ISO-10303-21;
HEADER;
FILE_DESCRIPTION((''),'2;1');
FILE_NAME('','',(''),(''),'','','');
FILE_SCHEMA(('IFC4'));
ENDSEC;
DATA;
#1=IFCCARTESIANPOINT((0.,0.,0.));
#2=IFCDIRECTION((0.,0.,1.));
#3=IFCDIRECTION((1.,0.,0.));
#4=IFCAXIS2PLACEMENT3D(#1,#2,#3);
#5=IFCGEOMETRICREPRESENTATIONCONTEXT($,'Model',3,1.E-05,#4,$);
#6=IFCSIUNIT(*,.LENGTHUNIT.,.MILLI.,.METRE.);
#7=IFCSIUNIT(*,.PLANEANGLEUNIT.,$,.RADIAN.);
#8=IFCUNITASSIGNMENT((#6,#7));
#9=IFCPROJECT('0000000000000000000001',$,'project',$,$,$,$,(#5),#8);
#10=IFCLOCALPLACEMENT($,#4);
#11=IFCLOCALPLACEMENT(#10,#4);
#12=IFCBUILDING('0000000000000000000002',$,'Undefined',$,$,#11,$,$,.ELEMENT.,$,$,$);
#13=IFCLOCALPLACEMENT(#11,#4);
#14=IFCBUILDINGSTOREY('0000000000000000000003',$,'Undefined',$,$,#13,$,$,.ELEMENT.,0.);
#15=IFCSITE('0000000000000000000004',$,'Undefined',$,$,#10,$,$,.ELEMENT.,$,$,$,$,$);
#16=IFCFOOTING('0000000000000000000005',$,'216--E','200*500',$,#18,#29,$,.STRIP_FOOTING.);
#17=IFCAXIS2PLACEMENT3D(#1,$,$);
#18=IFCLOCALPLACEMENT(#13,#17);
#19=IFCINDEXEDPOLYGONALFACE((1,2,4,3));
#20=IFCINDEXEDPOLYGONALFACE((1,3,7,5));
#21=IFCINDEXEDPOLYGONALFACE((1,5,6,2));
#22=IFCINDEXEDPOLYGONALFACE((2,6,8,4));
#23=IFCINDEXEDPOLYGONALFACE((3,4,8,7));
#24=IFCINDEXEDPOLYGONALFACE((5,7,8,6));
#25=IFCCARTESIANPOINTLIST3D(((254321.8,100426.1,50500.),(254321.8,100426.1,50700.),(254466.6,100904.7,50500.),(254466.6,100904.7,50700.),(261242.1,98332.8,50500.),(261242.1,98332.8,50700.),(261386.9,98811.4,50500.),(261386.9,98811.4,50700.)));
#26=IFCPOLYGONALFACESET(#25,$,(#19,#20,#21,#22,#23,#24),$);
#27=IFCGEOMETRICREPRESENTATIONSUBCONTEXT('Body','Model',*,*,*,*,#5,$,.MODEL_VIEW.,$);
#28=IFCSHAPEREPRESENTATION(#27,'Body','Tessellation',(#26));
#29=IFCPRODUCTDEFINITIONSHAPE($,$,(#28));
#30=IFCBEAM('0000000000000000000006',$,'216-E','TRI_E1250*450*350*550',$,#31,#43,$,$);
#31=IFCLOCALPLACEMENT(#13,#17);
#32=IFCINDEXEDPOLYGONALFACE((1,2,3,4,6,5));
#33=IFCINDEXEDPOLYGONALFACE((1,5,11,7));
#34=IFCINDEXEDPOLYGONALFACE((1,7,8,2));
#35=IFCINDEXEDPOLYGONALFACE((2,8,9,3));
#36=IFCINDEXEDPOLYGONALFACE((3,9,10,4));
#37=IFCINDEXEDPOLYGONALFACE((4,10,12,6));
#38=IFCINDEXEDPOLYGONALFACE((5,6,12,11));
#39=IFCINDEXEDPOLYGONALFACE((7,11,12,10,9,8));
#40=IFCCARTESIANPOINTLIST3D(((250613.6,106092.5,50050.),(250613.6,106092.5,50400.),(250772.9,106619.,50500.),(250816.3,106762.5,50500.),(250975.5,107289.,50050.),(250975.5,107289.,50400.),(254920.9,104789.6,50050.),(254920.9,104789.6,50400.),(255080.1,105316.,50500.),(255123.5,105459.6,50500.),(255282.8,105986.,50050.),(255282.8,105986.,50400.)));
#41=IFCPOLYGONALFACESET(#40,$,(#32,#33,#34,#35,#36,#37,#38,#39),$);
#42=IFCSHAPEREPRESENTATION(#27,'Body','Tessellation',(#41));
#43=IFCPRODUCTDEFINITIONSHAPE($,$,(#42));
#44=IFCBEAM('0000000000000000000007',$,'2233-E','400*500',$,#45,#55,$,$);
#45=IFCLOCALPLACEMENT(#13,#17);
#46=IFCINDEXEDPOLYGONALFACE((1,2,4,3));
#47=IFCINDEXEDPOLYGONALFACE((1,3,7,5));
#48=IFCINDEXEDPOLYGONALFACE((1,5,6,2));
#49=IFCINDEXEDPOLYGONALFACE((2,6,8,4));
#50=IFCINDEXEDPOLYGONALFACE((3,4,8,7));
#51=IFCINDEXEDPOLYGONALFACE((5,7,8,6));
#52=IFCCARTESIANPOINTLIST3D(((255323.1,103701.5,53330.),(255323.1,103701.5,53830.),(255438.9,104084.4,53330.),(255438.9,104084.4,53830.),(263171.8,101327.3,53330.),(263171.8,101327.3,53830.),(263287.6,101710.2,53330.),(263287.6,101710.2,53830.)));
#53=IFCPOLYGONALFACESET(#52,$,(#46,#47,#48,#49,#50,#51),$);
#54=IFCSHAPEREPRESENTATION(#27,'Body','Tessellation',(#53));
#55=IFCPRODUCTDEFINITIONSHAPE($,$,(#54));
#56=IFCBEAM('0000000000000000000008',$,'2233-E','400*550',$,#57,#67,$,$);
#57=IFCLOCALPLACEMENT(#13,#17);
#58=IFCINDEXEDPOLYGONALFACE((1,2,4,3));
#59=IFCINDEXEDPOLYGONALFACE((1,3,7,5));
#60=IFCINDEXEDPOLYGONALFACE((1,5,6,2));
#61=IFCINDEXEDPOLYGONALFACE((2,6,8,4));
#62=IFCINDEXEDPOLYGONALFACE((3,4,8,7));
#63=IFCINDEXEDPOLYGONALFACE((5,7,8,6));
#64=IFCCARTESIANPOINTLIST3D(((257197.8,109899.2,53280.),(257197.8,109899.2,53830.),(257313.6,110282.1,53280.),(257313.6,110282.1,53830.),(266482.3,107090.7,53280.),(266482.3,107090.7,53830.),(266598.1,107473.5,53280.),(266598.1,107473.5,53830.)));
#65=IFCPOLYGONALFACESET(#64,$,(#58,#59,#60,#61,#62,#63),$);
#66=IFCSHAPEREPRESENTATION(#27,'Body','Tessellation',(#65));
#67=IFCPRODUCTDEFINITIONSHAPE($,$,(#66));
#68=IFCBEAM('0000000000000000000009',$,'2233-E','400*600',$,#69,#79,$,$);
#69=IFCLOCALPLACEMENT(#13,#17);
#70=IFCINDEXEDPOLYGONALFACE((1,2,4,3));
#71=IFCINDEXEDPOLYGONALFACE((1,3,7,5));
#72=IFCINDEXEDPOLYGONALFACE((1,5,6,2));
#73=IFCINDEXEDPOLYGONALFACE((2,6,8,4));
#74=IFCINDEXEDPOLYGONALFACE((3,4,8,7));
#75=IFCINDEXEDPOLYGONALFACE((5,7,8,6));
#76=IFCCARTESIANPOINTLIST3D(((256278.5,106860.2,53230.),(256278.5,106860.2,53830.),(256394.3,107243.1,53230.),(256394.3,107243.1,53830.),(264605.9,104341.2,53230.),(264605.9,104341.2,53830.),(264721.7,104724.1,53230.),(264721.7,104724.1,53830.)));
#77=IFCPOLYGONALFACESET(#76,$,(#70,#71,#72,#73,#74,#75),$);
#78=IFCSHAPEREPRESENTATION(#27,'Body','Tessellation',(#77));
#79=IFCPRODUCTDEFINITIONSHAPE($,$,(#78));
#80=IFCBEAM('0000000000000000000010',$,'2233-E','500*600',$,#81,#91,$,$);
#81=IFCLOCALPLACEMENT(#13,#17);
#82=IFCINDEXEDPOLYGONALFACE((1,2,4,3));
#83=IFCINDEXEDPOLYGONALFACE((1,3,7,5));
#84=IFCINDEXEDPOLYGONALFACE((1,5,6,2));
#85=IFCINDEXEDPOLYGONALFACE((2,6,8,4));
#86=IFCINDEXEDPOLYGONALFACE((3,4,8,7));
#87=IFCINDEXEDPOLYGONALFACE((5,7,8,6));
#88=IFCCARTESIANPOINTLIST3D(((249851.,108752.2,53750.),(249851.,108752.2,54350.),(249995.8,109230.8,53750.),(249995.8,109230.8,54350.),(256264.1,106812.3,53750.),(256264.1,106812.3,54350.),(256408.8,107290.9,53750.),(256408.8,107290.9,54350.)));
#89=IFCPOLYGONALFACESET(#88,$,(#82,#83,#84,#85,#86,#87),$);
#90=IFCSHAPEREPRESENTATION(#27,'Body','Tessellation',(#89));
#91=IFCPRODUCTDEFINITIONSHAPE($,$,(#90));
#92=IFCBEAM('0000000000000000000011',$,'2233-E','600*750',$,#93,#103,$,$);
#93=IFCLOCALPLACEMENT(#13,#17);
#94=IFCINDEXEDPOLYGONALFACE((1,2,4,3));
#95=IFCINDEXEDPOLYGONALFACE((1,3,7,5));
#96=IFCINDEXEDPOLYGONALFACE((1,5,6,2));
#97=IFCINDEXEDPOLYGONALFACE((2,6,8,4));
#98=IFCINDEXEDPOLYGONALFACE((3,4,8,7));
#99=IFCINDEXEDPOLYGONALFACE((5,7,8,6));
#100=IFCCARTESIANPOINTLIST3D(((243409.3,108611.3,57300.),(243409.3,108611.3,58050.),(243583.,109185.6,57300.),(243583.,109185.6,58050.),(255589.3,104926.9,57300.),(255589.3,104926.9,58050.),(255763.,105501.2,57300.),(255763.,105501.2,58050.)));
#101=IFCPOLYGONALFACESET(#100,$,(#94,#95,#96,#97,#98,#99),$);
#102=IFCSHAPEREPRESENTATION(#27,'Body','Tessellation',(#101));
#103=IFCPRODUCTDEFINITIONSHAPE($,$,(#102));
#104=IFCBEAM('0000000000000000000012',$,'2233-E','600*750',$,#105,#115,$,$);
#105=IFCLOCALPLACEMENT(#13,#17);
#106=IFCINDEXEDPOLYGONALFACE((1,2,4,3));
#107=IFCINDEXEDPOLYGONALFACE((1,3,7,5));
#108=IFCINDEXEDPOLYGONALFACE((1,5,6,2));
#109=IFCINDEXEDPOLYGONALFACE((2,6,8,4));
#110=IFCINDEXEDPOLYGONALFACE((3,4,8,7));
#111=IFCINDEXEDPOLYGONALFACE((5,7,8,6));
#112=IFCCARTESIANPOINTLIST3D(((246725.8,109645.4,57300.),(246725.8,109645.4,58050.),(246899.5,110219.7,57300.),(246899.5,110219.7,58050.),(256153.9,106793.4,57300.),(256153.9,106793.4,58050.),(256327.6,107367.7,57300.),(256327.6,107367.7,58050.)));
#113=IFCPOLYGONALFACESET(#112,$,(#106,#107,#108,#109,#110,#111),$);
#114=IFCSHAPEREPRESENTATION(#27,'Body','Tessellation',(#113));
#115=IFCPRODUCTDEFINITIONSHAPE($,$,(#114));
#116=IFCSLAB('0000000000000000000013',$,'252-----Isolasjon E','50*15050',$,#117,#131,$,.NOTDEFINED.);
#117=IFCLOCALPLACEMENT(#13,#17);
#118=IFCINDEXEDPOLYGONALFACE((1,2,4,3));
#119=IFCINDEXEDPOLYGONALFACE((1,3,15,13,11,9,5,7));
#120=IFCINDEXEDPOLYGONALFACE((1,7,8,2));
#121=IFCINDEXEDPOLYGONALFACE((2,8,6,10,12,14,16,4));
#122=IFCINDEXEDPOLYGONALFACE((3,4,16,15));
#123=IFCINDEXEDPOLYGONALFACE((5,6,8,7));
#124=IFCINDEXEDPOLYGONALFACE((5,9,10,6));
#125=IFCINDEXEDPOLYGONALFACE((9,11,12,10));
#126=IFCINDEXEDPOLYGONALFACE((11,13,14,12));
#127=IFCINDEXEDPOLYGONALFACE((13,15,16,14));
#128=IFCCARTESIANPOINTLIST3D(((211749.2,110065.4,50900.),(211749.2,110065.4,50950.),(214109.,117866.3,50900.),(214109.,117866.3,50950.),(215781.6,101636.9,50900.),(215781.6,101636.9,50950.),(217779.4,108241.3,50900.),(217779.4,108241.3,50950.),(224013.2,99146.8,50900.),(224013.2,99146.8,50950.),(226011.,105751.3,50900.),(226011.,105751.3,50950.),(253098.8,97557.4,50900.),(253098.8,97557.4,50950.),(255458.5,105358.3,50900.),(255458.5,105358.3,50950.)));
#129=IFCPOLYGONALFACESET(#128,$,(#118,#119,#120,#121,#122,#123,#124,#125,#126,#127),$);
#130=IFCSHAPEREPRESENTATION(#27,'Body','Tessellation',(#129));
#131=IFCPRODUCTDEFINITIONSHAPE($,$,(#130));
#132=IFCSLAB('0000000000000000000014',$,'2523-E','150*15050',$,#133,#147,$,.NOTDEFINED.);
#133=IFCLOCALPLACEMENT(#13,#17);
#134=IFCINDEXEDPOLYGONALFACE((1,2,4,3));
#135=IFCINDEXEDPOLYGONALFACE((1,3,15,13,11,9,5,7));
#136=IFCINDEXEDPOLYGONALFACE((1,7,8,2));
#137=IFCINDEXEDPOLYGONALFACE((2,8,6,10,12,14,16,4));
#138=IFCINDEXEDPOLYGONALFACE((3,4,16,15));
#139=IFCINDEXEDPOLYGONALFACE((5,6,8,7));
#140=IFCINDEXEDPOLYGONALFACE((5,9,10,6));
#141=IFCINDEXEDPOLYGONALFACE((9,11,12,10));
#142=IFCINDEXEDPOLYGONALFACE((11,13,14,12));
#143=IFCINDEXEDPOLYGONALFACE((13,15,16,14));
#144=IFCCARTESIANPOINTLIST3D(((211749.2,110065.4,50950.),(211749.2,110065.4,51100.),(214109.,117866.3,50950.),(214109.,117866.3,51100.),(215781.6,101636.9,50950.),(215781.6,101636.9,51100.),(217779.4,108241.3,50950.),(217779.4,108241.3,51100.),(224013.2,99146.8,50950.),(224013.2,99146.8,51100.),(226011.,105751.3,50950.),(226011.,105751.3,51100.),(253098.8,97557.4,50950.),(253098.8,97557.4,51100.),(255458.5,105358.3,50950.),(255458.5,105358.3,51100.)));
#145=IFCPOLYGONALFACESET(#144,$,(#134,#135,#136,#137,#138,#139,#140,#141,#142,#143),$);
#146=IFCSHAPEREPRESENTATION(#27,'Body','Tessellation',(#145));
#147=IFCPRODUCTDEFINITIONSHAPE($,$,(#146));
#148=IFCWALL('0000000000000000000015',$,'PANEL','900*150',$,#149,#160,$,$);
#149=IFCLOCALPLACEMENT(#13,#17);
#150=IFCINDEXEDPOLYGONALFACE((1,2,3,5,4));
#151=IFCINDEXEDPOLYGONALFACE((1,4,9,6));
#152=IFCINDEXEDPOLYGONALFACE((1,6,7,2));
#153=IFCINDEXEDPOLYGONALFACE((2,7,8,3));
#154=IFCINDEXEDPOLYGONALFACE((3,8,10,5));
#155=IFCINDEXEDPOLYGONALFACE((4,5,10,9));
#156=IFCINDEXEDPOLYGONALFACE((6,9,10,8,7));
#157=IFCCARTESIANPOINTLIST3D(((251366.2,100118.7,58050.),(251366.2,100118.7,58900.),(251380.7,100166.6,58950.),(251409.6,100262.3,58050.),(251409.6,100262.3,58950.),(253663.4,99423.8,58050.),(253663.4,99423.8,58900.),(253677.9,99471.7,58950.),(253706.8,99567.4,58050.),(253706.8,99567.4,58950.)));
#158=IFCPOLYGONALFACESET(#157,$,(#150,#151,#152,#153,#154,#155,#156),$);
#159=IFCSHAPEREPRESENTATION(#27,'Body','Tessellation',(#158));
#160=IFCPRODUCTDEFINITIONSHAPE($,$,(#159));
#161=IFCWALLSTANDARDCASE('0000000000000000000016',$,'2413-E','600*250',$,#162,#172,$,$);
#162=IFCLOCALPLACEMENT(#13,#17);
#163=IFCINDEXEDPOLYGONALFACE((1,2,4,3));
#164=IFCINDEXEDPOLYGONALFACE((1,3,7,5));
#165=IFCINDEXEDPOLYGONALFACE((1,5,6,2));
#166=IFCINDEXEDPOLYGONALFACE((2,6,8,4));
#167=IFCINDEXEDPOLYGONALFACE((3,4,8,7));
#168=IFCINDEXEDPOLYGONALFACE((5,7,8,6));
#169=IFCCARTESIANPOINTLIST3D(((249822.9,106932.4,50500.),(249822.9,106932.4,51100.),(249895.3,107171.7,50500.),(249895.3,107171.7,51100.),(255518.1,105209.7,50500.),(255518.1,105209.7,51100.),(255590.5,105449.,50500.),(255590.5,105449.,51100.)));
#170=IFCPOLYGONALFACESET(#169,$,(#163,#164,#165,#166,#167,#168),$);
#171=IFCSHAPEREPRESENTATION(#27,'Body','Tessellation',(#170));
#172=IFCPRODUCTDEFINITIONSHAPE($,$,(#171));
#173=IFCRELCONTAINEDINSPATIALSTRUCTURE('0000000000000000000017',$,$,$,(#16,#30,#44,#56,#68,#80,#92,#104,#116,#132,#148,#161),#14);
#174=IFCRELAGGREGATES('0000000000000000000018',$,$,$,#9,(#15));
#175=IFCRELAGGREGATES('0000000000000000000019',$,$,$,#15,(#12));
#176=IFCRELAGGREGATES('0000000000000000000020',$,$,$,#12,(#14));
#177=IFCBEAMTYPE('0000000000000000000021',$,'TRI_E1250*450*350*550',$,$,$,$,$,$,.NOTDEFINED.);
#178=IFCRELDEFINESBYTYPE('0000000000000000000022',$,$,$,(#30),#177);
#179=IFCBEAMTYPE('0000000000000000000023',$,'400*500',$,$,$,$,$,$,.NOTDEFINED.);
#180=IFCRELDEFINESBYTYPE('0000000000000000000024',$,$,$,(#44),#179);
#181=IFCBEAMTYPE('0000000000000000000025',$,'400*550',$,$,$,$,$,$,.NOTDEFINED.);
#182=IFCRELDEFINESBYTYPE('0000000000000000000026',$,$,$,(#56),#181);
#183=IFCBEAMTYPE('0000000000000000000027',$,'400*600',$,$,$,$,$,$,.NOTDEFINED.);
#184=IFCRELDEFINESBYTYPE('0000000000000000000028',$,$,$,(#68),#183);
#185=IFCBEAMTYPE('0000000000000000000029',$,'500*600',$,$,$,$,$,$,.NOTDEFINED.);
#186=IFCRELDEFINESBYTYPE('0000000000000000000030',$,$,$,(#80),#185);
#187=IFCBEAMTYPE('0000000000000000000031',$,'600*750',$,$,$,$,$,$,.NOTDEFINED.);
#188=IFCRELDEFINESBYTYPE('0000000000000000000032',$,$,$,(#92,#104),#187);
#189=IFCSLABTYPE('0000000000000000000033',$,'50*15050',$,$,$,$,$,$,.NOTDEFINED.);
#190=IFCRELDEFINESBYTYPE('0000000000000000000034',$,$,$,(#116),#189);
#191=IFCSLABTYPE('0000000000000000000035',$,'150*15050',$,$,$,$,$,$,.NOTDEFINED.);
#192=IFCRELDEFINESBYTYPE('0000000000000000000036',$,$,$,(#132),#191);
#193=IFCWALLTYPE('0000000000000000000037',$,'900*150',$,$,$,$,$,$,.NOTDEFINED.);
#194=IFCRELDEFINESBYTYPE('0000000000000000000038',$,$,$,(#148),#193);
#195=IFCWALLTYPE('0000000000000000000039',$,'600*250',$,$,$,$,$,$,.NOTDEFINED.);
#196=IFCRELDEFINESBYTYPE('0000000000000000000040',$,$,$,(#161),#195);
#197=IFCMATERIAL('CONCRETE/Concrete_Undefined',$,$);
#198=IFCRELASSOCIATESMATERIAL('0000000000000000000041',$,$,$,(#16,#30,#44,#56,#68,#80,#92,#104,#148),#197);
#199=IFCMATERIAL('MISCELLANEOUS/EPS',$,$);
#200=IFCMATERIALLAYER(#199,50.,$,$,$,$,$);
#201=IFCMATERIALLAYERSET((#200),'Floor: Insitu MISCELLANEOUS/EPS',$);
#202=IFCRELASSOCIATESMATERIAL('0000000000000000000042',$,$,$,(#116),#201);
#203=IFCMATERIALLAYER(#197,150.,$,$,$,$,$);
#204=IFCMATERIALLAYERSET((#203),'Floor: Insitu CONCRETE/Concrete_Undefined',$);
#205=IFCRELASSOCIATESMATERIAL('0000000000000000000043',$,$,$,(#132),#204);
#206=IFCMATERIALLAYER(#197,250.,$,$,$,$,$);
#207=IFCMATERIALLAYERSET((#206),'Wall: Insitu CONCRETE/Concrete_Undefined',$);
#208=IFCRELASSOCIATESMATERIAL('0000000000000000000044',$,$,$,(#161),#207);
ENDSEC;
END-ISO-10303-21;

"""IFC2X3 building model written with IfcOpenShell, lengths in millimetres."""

from ifc_helpers import new_model, si_unit, frame, frame_2d, origin_with_axes, origin_2d_with_axis, place, context, subcontext, project, spatial, polyline, rectangle, outline, extrude, clip, halfspace, material, layer, layer_set, layer_usage, type_object, element, save


model = new_model("IFC2X3")

# Units and contexts
model_context = context("Model", 3, precision=1e-05, world=origin_with_axes())
body_context = subcontext(model_context, "Body", "Model", "MODEL_VIEW")
ifc_project = project(units=[si_unit("LENGTHUNIT", "METRE", prefix="MILLI"), si_unit("PLANEANGLEUNIT", "RADIAN")], contexts=[model_context])

# Site, building, storey
site_placement = place(None, origin_with_axes())
site = spatial("IfcSite", under=ifc_project, at=site_placement, Name="Undefined", CompositionType="ELEMENT")
building_placement = place(site_placement, origin_with_axes())
building = spatial("IfcBuilding", under=site, at=building_placement, Name="Undefined", CompositionType="ELEMENT")
storey_placement = place(building_placement, origin_with_axes())
storey = spatial("IfcBuildingStorey", under=building, at=storey_placement, Name="Undefined", CompositionType="ELEMENT", Elevation=0.0)

# Footing
ifc_material_1 = material(Name="CONCRETE/Concrete_Undefined")
footing_placement = place(storey_placement, frame((254394.2, 100665.4, 50600.0), z_axis=(0.0, 0.0, 1.0), x_axis=(0.957167, -0.289538, 0.0)))
element("IfcFooting", 1, at=footing_placement, inside=storey, material=ifc_material_1, Name="216--E", Description="200*500", PredefinedType="STRIP_FOOTING", context=body_context, shape_type="SweptSolid", body=[
    extrude(rectangle(XDim=500.0, YDim=200.0, at=origin_2d_with_axis()), frame((7230.0, 0.0, 0.0), z_axis=(-1.0, 0.0, 0.0), x_axis=(0.0, -1.0, 0.0)), (0.0, 0.0, 1.0), 7230.0),
])

# Beams
beam_type_1 = type_object("IfcBeamType", Name="TRI_E1250*450*350*550", PredefinedType="NOTDEFINED")
beam_1_placement = place(storey_placement, frame((250794.6, 106690.7, 50275.0), z_axis=(0.0, 0.0, 1.0), x_axis=(0.957167, -0.289538, 0.0)))
element("IfcBeam", 2, at=beam_1_placement, inside=storey, type_object=beam_type_1, material=ifc_material_1, Name="216-E", Description="TRI_E1250*450*350*550", context=body_context, shape_type="SweptSolid", body=[
    extrude(outline(polyline([(625.0, -225.0), (-625.0, -225.0), (-625.0, 125.0), (-75.0, 225.0), (75.0, 225.0), (625.0, 125.0), (625.0, -225.0)])), frame((4500.0, 0.0, 0.0), z_axis=(-1.0, 0.0, 0.0), x_axis=(0.0, -1.0, 0.0)), (0.0, 0.0, 1.0), 4500.0),
])
beam_type_2 = type_object("IfcBeamType", Name="400*500", PredefinedType="NOTDEFINED")
beam_2_placement = place(storey_placement, frame((263229.7, 101518.8, 53580.0), z_axis=(-0.289538, -0.957167, 0.0), x_axis=(-0.957167, 0.289538, 0.0)))
element("IfcBeam", 3, at=beam_2_placement, inside=storey, type_object=beam_type_2, material=ifc_material_1, Name="2233-E", Description="400*500", context=body_context, shape_type="SweptSolid", body=[
    extrude(rectangle(XDim=500.0, YDim=400.0, at=origin_2d_with_axis()), frame((8200.0, 0.0, 0.0), z_axis=(-1.0, 0.0, 0.0), x_axis=(0.0, -1.0, 0.0)), (0.0, 0.0, 1.0), 8200.0),
])
beam_type_3 = type_object("IfcBeamType", Name="400*550", PredefinedType="NOTDEFINED")
beam_3_placement = place(storey_placement, frame((266540.2, 107282.1, 53555.0), z_axis=(-0.289538, -0.957167, 0.0), x_axis=(-0.957167, 0.289538, 0.0)))
element("IfcBeam", 4, at=beam_3_placement, inside=storey, type_object=beam_type_3, material=ifc_material_1, Name="2233-E", Description="400*550", context=body_context, shape_type="SweptSolid", body=[
    extrude(rectangle(XDim=550.0, YDim=400.0, at=origin_2d_with_axis()), frame((9700.0, 0.0, 0.0), z_axis=(-1.0, 0.0, 0.0), x_axis=(0.0, -1.0, 0.0)), (0.0, 0.0, 1.0), 9700.0),
])
beam_type_4 = type_object("IfcBeamType", Name="400*600", PredefinedType="NOTDEFINED")
beam_4_placement = place(storey_placement, frame((264663.8, 104532.6, 53530.0), z_axis=(-0.289538, -0.957167, 0.0), x_axis=(-0.957167, 0.289538, 0.0)))
element("IfcBeam", 5, at=beam_4_placement, inside=storey, type_object=beam_type_4, material=ifc_material_1, Name="2233-E", Description="400*600", context=body_context, shape_type="SweptSolid", body=[
    extrude(rectangle(XDim=600.0, YDim=400.0, at=origin_2d_with_axis()), frame((8700.0, 0.0, 0.0), z_axis=(-1.0, 0.0, 0.0), x_axis=(0.0, -1.0, 0.0)), (0.0, 0.0, 1.0), 8700.0),
])
beam_type_5 = type_object("IfcBeamType", Name="500*600", PredefinedType="NOTDEFINED")
beam_5_placement = place(storey_placement, frame((256336.4, 107051.6, 54050.0), z_axis=(-0.289538, -0.957167, 0.0), x_axis=(-0.957167, 0.289538, 0.0)))
element("IfcBeam", 6, at=beam_5_placement, inside=storey, type_object=beam_type_5, material=ifc_material_1, Name="2233-E", Description="500*600", context=body_context, shape_type="SweptSolid", body=[
    extrude(rectangle(XDim=600.0, YDim=500.0, at=origin_2d_with_axis()), frame((6700.0, 0.0, 0.0), z_axis=(-1.0, 0.0, 0.0), x_axis=(0.0, -1.0, 0.0)), (0.0, 0.0, 1.0), 6700.0),
])
beam_type_6 = type_object("IfcBeamType", Name="600*750", PredefinedType="NOTDEFINED")
beam_6_placement = place(storey_placement, frame((255676.1, 105214.1, 57675.0), z_axis=(-0.289538, -0.957167, 0.0), x_axis=(-0.957167, 0.289538, 0.0)))
element("IfcBeam", 7, at=beam_6_placement, inside=storey, type_object=beam_type_6, material=ifc_material_1, Name="2233-E", Description="600*750", context=body_context, shape_type="SweptSolid", body=[
    extrude(rectangle(XDim=750.0, YDim=600.0, at=origin_2d_with_axis()), frame((12725.0, 0.0, 0.0), z_axis=(-1.0, 0.0, 0.0), x_axis=(0.0, -1.0, 0.0)), (0.0, 0.0, 1.0), 12725.0),
])
beam_7_placement = place(storey_placement, frame((256240.7, 107080.6, 57675.0), z_axis=(-0.289538, -0.957167, 0.0), x_axis=(-0.957167, 0.289538, 0.0)))
element("IfcBeam", 8, at=beam_7_placement, inside=storey, type_object=beam_type_6, material=ifc_material_1, Name="2233-E", Description="600*750", context=body_context, shape_type="SweptSolid", body=[
    extrude(rectangle(XDim=750.0, YDim=600.0, at=origin_2d_with_axis()), frame((9850.0, 0.0, 0.0), z_axis=(-1.0, 0.0, 0.0), x_axis=(0.0, -1.0, 0.0)), (0.0, 0.0, 1.0), 9850.0),
])

# Slabs
ifc_material_2 = material(Name="MISCELLANEOUS/EPS")
ifc_layer_1 = layer(ifc_material_2, 50.0)
ifc_layer_set_1 = layer_set([ifc_layer_1], Name="Floor: Insitu MISCELLANEOUS/EPS")
ifc_layer_usage_1 = layer_usage(ifc_layer_set_1, "AXIS3", "POSITIVE", -25.0)
slab_type_1 = type_object("IfcSlabType", Name="50*15050", PredefinedType="NOTDEFINED")
slab_1_placement = place(storey_placement, frame((255458.5, 105358.3, 50925.0), z_axis=(0.0, 0.0, 1.0), x_axis=(-0.957167, 0.289538, 0.0)))
element("IfcSlab", 9, at=slab_1_placement, inside=storey, type_object=slab_type_1, material=ifc_layer_usage_1, Name="252-----Isolasjon E", Description="50*15050", PredefinedType="NOTDEFINED", context=body_context, shape_type="SweptSolid", body=[
    extrude(outline(polyline([(0.0, 0.0), (43200.0, 0.0), (43200.0, 8150.0), (36900.0, 8150.0), (36900.0, 15050.0), (28300.0, 15050.0), (28300.0, 8150.0), (0.0, 8150.0), (0.0, 0.0)])), frame((0.0, 0.0, -25.0), z_axis=(0.0, 0.0, 1.0), x_axis=(1.0, 0.0, 0.0)), (0.0, 0.0, 1.0), 50.0),
])
ifc_layer_2 = layer(ifc_material_1, 150.0)
ifc_layer_set_2 = layer_set([ifc_layer_2], Name="Floor: Insitu CONCRETE/Concrete_Undefined")
ifc_layer_usage_2 = layer_usage(ifc_layer_set_2, "AXIS3", "POSITIVE", -75.0)
slab_type_2 = type_object("IfcSlabType", Name="150*15050", PredefinedType="NOTDEFINED")
slab_2_placement = place(storey_placement, frame((255458.5, 105358.3, 51025.0), z_axis=(0.0, 0.0, 1.0), x_axis=(-0.957167, 0.289538, 0.0)))
element("IfcSlab", 10, at=slab_2_placement, inside=storey, type_object=slab_type_2, material=ifc_layer_usage_2, Name="2523-E", Description="150*15050", PredefinedType="NOTDEFINED", context=body_context, shape_type="SweptSolid", body=[
    extrude(outline(polyline([(0.0, 0.0), (43200.0, 0.0), (43200.0, 8150.0), (36900.0, 8150.0), (36900.0, 15050.0), (28300.0, 15050.0), (28300.0, 8150.0), (0.0, 8150.0), (0.0, 0.0)])), frame((0.0, 0.0, -75.0), z_axis=(0.0, 0.0, 1.0), x_axis=(1.0, 0.0, 0.0)), (0.0, 0.0, 1.0), 150.0),
])

# Walls
wall_type_1 = type_object("IfcWallType", Name="900*150", PredefinedType="NOTDEFINED")
wall_1_placement = place(storey_placement, frame((251387.9, 100190.5, 58050.0), z_axis=(0.0, 0.0, 1.0), x_axis=(0.957166, -0.289539, 0.0)))
element("IfcWall", 11, at=wall_1_placement, inside=storey, type_object=wall_type_1, material=ifc_material_1, Name="PANEL", Description="900*150", context=body_context, shape_type="Clipping", body=[
    clip(extrude(rectangle(XDim=2400.0, YDim=150.0, at=frame_2d((0.0, 1200.0), x_axis=(0.0, -1.0))), frame((0.0, 0.0, 0.0), z_axis=(0.0, 0.0, 1.0), x_axis=(0.0, -1.0, 0.0)), (0.0, 0.0, 1.0), 900.0), halfspace(frame((2400.0, 75.0, 1000.0), z_axis=(0.000001, -0.707072, 0.707141), x_axis=(0.0, -0.707141, -0.707072)), False)),
])
ifc_layer_3 = layer(ifc_material_1, 250.0)
ifc_layer_set_3 = layer_set([ifc_layer_3], Name="Wall: Insitu CONCRETE/Concrete_Undefined")
ifc_layer_usage_3 = layer_usage(ifc_layer_set_3, "AXIS2", "POSITIVE", -125.0)
wall_type_2 = type_object("IfcWallType", Name="600*250", PredefinedType="NOTDEFINED")
wall_2_placement = place(storey_placement, frame((249859.1, 107052.1, 50500.0), z_axis=(0.0, 0.0, 1.0), x_axis=(0.957167, -0.289537, 0.0)))
element("IfcWallStandardCase", 12, at=wall_2_placement, inside=storey, type_object=wall_type_2, material=ifc_layer_usage_3, Name="2413-E", Description="600*250", context=body_context, shape_type="SweptSolid", body=[
    extrude(rectangle(XDim=5950.0, YDim=250.0, at=frame_2d((0.0, 2975.0), x_axis=(0.0, -1.0))), frame((0.0, 0.0, 0.0), z_axis=(0.0, 0.0, 1.0), x_axis=(0.0, -1.0, 0.0)), (0.0, 0.0, 1.0), 600.0),
])

save(model, "model.ifc")
